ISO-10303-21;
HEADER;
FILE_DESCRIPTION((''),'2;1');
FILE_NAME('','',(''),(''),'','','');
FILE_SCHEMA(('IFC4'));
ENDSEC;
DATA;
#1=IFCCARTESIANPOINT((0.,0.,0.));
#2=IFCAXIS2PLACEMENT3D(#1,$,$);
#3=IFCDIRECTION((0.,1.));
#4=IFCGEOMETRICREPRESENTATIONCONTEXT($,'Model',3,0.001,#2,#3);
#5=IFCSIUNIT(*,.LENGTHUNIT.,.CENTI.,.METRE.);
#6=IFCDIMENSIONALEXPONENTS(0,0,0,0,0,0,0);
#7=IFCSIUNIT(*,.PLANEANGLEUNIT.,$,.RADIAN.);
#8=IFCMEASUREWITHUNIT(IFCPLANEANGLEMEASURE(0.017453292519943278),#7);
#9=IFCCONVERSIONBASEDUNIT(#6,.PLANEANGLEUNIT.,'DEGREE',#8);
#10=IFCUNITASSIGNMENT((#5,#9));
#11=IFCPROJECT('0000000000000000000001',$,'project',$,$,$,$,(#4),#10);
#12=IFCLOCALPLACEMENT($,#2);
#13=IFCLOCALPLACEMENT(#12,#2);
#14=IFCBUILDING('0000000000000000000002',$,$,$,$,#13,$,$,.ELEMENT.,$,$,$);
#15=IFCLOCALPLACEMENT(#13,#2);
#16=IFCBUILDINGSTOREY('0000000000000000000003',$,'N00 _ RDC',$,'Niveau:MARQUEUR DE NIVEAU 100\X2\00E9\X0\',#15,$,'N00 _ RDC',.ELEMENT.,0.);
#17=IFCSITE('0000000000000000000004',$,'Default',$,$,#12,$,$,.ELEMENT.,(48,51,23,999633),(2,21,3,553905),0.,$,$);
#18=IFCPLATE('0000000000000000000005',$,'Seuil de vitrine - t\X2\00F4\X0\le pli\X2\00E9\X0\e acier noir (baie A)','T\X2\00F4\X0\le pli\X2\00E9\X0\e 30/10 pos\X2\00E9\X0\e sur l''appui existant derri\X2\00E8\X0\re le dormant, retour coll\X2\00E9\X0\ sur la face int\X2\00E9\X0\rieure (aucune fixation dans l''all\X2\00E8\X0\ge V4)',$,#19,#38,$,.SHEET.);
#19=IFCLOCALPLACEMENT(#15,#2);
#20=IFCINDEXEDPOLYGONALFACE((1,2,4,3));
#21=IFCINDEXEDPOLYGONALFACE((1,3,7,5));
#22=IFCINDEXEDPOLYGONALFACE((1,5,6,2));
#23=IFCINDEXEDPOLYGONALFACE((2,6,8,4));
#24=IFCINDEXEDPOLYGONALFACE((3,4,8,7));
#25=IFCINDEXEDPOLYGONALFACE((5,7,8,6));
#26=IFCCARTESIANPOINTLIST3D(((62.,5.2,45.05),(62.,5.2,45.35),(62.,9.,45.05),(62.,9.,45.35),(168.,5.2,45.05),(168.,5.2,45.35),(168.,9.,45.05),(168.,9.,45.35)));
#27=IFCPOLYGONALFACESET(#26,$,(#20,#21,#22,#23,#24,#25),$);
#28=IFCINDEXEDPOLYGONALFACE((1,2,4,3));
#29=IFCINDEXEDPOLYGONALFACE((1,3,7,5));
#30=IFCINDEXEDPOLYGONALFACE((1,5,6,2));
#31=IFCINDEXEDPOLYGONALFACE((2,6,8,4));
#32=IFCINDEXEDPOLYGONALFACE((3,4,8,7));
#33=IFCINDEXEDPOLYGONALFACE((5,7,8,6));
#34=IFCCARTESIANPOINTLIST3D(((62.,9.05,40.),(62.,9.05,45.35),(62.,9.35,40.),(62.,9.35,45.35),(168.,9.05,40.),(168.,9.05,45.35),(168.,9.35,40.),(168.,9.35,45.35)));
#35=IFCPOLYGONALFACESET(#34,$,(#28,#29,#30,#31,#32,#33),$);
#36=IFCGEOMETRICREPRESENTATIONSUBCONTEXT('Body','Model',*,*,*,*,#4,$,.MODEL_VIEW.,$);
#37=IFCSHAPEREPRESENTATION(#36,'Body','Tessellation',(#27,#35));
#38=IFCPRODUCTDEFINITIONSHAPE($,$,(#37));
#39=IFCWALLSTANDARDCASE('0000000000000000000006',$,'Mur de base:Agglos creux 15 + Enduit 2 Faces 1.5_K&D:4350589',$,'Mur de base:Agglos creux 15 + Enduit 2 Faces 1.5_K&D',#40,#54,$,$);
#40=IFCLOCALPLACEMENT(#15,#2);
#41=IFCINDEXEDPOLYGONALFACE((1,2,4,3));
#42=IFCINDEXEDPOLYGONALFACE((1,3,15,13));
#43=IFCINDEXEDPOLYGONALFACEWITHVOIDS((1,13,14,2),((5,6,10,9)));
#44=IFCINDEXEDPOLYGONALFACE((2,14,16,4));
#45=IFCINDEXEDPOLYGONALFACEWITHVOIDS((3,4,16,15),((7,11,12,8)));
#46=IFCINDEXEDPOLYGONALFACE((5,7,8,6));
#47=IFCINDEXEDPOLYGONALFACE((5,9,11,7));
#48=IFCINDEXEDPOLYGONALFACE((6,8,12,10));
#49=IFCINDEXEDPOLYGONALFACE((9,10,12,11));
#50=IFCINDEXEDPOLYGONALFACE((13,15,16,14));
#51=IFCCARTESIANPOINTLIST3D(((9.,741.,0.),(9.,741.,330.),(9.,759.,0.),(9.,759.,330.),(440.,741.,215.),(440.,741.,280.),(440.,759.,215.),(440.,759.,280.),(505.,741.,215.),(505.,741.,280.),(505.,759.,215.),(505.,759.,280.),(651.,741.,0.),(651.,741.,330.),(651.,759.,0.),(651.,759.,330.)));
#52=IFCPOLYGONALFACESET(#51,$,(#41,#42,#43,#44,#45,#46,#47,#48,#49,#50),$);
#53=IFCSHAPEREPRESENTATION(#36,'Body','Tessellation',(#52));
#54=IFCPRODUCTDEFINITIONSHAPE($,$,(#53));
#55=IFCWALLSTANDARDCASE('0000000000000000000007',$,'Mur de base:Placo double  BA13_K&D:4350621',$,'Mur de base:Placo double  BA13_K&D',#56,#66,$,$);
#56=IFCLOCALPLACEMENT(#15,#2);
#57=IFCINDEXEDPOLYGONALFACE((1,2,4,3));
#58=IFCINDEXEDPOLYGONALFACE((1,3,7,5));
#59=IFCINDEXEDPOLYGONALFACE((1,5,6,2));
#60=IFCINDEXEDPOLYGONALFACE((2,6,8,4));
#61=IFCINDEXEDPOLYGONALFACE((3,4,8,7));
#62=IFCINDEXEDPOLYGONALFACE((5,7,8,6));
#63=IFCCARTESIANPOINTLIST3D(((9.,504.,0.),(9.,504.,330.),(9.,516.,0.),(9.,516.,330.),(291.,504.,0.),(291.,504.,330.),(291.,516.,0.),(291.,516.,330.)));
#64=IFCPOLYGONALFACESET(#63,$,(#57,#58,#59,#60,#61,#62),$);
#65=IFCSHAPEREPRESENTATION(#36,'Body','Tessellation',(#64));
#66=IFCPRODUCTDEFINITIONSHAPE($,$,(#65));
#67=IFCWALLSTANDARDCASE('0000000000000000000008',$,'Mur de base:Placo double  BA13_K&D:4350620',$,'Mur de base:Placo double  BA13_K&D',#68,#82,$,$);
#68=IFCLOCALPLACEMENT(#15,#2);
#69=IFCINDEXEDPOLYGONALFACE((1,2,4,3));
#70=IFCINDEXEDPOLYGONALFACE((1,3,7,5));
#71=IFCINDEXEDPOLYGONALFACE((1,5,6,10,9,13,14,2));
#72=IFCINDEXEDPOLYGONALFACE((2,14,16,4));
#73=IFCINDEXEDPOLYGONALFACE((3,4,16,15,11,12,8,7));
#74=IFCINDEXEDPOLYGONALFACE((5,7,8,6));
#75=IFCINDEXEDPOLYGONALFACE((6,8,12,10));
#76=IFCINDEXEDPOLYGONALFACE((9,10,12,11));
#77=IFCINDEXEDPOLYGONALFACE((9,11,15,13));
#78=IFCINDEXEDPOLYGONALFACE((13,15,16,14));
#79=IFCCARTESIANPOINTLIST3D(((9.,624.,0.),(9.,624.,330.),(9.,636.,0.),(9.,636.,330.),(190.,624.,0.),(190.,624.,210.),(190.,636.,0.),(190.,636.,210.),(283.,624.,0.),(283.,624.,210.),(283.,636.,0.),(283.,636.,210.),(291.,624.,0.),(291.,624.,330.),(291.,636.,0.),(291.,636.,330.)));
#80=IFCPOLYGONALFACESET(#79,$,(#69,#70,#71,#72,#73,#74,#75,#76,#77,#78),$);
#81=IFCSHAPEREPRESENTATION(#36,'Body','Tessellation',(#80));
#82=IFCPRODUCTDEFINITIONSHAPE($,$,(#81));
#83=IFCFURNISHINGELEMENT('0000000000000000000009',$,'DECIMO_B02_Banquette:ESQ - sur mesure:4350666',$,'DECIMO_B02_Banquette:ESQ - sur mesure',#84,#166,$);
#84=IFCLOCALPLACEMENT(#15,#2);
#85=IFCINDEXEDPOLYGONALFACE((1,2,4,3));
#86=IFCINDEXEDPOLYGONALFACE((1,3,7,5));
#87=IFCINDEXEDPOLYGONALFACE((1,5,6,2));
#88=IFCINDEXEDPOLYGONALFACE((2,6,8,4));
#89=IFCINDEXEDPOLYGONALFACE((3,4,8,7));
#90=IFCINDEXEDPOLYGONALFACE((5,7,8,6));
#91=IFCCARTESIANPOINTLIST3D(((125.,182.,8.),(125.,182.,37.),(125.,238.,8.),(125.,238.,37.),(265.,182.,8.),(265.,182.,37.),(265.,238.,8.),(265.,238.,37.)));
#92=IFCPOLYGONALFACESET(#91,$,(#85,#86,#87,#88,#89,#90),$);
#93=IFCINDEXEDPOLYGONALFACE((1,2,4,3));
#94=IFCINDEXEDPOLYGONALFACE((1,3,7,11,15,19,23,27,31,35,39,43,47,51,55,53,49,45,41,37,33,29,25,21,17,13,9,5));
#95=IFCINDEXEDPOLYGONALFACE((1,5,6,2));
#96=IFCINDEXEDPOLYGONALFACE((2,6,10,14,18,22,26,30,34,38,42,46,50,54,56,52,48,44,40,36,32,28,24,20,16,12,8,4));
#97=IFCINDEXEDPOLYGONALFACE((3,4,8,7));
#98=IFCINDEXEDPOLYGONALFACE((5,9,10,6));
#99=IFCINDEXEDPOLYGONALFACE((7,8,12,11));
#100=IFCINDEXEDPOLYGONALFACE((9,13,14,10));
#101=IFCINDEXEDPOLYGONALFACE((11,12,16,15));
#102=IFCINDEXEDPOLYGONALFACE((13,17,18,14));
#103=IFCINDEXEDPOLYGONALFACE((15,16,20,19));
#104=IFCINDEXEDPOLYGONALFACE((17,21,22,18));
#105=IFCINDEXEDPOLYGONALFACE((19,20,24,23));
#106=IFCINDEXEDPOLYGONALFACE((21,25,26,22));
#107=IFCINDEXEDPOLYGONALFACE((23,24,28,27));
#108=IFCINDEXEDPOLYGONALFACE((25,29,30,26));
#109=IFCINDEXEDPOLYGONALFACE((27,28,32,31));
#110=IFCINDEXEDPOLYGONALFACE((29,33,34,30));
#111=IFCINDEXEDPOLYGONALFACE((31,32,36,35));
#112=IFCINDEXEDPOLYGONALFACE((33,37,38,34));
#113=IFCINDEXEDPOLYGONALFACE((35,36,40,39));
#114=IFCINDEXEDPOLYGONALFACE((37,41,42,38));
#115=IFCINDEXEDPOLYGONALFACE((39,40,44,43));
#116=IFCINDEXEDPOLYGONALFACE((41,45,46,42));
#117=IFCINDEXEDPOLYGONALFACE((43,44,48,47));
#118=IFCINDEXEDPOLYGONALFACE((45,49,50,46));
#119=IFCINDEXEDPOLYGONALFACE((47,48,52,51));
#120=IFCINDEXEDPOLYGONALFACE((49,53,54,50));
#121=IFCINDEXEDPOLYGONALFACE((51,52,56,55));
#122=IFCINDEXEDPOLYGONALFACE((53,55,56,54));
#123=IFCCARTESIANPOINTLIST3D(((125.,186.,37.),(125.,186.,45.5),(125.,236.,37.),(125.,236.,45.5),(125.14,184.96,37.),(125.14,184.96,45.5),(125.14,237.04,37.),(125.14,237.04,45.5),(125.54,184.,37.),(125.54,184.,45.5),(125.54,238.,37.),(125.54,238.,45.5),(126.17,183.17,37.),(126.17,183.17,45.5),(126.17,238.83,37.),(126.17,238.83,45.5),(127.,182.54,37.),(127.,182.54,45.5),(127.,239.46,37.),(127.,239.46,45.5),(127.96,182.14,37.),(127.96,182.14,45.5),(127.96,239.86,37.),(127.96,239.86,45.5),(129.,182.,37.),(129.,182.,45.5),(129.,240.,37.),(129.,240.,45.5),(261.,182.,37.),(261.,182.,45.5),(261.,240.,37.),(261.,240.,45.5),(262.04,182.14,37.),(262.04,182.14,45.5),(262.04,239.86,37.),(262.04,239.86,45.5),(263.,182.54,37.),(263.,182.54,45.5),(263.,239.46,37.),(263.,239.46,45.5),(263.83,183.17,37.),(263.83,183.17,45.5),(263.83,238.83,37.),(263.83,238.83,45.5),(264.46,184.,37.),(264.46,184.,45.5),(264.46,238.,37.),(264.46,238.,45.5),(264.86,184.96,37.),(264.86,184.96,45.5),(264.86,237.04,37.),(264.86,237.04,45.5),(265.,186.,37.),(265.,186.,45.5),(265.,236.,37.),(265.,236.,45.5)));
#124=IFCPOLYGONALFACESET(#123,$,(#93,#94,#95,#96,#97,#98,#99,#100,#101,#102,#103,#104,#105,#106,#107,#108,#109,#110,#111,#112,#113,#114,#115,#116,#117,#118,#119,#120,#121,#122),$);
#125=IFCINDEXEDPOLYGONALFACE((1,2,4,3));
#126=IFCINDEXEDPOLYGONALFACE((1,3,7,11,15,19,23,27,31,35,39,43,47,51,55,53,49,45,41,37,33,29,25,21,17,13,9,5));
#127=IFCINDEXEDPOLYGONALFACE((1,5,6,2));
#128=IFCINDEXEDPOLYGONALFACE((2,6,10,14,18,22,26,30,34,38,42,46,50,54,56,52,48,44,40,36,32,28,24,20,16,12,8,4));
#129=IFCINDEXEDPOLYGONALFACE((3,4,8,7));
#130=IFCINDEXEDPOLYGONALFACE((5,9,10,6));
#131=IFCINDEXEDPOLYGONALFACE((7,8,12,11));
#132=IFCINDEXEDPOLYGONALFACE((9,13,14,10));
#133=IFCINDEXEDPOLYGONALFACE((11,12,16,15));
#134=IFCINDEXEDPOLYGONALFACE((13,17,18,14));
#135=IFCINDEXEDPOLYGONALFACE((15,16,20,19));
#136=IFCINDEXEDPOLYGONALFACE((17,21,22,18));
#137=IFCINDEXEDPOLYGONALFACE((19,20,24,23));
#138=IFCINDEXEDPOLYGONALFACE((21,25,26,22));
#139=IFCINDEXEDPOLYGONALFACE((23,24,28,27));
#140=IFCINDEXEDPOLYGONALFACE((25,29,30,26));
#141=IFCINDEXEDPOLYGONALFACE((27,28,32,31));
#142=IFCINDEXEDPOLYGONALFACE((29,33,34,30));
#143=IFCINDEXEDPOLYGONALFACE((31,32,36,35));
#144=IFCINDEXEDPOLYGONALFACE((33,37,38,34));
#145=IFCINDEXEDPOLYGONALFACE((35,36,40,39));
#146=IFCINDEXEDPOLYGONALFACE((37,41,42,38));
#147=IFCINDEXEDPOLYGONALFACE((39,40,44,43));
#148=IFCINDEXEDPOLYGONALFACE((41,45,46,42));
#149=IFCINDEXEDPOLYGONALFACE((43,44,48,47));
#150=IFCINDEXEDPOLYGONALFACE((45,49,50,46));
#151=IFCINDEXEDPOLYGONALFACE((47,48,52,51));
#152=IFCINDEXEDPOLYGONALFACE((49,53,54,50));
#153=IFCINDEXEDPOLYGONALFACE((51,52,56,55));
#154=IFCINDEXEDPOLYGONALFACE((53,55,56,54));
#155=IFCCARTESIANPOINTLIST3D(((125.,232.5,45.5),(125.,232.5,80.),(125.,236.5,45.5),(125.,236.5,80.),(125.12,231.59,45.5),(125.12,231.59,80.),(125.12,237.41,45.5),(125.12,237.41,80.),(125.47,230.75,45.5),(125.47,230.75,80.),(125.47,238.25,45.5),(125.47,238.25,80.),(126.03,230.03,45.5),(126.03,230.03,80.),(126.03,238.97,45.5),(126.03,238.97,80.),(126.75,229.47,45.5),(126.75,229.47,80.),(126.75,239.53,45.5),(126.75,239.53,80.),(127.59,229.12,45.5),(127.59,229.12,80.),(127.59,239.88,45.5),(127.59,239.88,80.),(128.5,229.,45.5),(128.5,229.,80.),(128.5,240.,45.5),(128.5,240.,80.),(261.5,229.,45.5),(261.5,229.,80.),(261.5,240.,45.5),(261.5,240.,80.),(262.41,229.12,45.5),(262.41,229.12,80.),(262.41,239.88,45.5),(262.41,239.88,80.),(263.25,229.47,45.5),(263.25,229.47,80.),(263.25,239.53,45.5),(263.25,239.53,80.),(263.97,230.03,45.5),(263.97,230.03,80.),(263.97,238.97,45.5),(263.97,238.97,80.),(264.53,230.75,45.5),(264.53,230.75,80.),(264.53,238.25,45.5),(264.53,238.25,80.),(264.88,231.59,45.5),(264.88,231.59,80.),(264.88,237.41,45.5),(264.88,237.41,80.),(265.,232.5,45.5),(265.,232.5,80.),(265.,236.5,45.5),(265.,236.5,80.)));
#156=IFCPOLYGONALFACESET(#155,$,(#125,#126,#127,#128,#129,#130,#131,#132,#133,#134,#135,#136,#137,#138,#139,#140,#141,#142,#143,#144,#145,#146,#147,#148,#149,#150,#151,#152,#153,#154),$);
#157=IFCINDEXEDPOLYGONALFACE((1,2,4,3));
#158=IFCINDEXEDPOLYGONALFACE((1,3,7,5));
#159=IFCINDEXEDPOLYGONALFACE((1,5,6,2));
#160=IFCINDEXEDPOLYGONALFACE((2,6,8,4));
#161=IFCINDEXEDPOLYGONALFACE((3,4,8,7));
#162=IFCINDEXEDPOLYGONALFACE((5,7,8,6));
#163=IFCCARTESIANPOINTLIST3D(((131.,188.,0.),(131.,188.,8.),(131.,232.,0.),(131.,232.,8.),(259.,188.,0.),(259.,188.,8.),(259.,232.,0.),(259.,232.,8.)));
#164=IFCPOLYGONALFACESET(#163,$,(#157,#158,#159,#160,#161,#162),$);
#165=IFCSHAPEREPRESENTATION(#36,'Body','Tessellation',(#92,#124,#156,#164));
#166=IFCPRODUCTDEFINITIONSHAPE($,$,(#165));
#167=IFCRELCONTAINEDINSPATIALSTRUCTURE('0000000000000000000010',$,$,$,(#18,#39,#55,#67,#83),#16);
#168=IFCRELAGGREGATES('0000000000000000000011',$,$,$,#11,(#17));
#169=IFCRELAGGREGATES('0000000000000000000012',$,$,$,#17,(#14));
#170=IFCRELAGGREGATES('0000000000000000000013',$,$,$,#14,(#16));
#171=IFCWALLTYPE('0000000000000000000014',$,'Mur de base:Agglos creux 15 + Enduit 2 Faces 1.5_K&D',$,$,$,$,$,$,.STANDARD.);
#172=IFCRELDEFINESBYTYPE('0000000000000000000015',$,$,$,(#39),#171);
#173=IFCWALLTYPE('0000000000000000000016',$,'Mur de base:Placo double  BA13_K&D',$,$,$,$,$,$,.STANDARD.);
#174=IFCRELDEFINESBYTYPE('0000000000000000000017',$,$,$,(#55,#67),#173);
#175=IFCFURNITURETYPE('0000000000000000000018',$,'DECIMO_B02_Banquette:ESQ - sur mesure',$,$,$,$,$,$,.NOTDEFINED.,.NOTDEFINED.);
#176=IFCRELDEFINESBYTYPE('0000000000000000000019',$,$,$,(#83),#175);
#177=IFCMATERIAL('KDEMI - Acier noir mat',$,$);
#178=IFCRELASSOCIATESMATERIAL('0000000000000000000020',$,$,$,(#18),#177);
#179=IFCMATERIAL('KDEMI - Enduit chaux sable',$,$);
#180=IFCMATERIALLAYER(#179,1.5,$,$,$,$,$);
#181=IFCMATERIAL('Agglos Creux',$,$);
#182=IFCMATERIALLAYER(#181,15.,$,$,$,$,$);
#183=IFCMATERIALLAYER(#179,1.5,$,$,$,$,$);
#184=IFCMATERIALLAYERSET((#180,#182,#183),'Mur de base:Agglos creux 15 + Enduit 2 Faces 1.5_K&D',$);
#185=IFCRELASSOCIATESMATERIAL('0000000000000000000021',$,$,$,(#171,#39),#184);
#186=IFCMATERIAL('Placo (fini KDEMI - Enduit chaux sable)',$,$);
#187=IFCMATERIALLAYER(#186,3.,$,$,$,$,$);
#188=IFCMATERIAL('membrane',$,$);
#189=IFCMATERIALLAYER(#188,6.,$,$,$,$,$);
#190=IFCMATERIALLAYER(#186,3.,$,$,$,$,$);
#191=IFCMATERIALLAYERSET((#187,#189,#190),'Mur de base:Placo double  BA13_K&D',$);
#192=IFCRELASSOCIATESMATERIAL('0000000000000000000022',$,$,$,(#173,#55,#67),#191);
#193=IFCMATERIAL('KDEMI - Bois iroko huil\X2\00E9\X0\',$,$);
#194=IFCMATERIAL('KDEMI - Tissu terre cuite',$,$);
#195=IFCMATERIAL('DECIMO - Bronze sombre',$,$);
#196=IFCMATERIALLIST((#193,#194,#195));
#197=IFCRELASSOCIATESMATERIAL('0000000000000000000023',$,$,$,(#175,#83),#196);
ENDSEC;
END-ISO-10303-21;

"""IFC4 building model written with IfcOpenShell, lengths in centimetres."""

from ifc_helpers import new_model, entity, si_unit, converted_unit, direction, frame, frame_2d, origin, origin_with_axes, origin_2d_with_axis, place, context, subcontext, project, spatial, polyline, circle_curve, parameter, trimmed, segment, composite_curve, rectangle, outline, extrude, source, transform, mapped, material, material_list, layer, layer_set, layer_usage, type_object, type_shapes, element, save


model = new_model("IFC4")

# Units and contexts
model_context = context("Model", 3, precision=0.001, world=origin(), true_north=direction((0.0, 1.0)))
body_context = subcontext(model_context, "Body", "Model", "MODEL_VIEW")
ifc_project = project(units=[si_unit("LENGTHUNIT", "METRE", prefix="CENTI"), converted_unit("PLANEANGLEUNIT", "DEGREE", entity("IfcPlaneAngleMeasure", 0.017453292519943278), si_unit("PLANEANGLEUNIT", "RADIAN"), dimensions=[0, 0, 0, 0, 0, 0, 0])], contexts=[model_context])

# Site, building, storey
site_placement = place(None, origin())
site = spatial("IfcSite", under=ifc_project, at=site_placement, Name="Default", CompositionType="ELEMENT", RefLatitude=(48, 51, 23, 999633), RefLongitude=(2, 21, 3, 553905), RefElevation=0.0)
building_placement = place(site_placement, origin())
building = spatial("IfcBuilding", under=site, at=building_placement, CompositionType="ELEMENT")
storey_placement = place(building_placement, origin())
storey = spatial("IfcBuildingStorey", under=building, at=storey_placement, Name="N00 _ RDC", ObjectType="Niveau:MARQUEUR DE NIVEAU 100é", LongName="N00 _ RDC", CompositionType="ELEMENT", Elevation=0.0)

# Plate
ifc_material_1 = material(Name="KDEMI - Acier noir mat")
plate_placement = place(storey_placement, origin_with_axes())
element("IfcPlate", 1, at=plate_placement, inside=storey, material=ifc_material_1, Name="Seuil de vitrine - tôle pliée acier noir (baie A)", Description="Tôle pliée 30/10 posée sur l'appui existant derrière le dormant, retour collé sur la face intérieure (aucune fixation dans l'allège V4)", PredefinedType="SHEET", context=body_context, shape_type="SweptSolid", body=[
    extrude(rectangle(XDim=106.0, YDim=3.8, at=frame_2d((115.0, 7.1))), frame((0.0, 0.0, 45.05)), (0.0, 0.0, 1.0), 0.3),
    extrude(rectangle(XDim=106.0, YDim=0.3, at=frame_2d((115.0, 9.2))), frame((0.0, 0.0, 40.0)), (0.0, 0.0, 1.0), 5.35),
])

# Wall, opening
ifc_material_2 = material(Name="KDEMI - Enduit chaux sable")
ifc_layer_1 = layer(ifc_material_2, 1.5)
ifc_material_3 = material(Name="Agglos Creux")
ifc_layer_2 = layer(ifc_material_3, 15.0)
ifc_layer_3 = layer(ifc_material_2, 1.5)
ifc_layer_set_1 = layer_set([ifc_layer_1, ifc_layer_2, ifc_layer_3], Name="Mur de base:Agglos creux 15 + Enduit 2 Faces 1.5_K&D")
ifc_layer_usage_1 = layer_usage(ifc_layer_set_1, "AXIS2", "NEGATIVE", 9.0)
wall_type_1 = type_object("IfcWallType", Name="Mur de base:Agglos creux 15 + Enduit 2 Faces 1.5_K&D", PredefinedType="STANDARD", material=ifc_layer_set_1)
wall_1_placement = place(storey_placement, frame((9.0, 750.0, 0.0)))
wall_1 = element("IfcWallStandardCase", 2, at=wall_1_placement, inside=storey, type_object=wall_type_1, material=ifc_layer_usage_1, Name="Mur de base:Agglos creux 15 + Enduit 2 Faces 1.5_K&D:4350589", ObjectType="Mur de base:Agglos creux 15 + Enduit 2 Faces 1.5_K&D", context=body_context, shape_type="SweptSolid", body=[
    extrude(rectangle(XDim=642.0, YDim=18.0, at=frame_2d((321.0, 0.0), x_axis=(-1.0, 0.0))), origin(), (0.0, 0.0, 1.0), 330.0),
])
opening_1_placement = place(wall_1_placement, origin())
element("IfcOpeningElement", 3, at=opening_1_placement, cuts=wall_1, ObjectType="Opening", context=body_context, shape_type="SweptSolid", body=[
    extrude(rectangle(XDim=65.0, YDim=65.0, at=frame_2d((0.0, 0.0), x_axis=(1.0, 0.0))), frame((463.5, -9.0, 247.5), z_axis=(0.0, 1.0, 0.0), x_axis=(0.0, 0.0, -1.0)), (0.0, 0.0, 1.0), 18.0),
])

# Wall
ifc_material_4 = material(Name="Placo (fini KDEMI - Enduit chaux sable)")
ifc_layer_4 = layer(ifc_material_4, 3.0)
ifc_material_5 = material(Name="membrane")
ifc_layer_5 = layer(ifc_material_5, 6.0)
ifc_layer_6 = layer(ifc_material_4, 3.0)
ifc_layer_set_2 = layer_set([ifc_layer_4, ifc_layer_5, ifc_layer_6], Name="Mur de base:Placo double  BA13_K&D")
ifc_layer_usage_2 = layer_usage(ifc_layer_set_2, "AXIS2", "POSITIVE", -6.0)
wall_type_2 = type_object("IfcWallType", Name="Mur de base:Placo double  BA13_K&D", PredefinedType="STANDARD", material=ifc_layer_set_2)
wall_2_placement = place(storey_placement, frame((9.0, 510.0, 0.0)))
element("IfcWallStandardCase", 4, at=wall_2_placement, inside=storey, type_object=wall_type_2, material=ifc_layer_usage_2, Name="Mur de base:Placo double  BA13_K&D:4350621", ObjectType="Mur de base:Placo double  BA13_K&D", context=body_context, shape_type="SweptSolid", body=[
    extrude(rectangle(XDim=282.0, YDim=12.0, at=frame_2d((141.0, 0.0), x_axis=(-1.0, 0.0))), origin(), (0.0, 0.0, 1.0), 330.0),
])

# Wall, opening
ifc_layer_usage_3 = layer_usage(ifc_layer_set_2, "AXIS2", "NEGATIVE", 6.0)
wall_3_placement = place(storey_placement, frame((9.0, 630.0, 0.0)))
wall_3 = element("IfcWallStandardCase", 5, at=wall_3_placement, inside=storey, type_object=wall_type_2, material=ifc_layer_usage_3, Name="Mur de base:Placo double  BA13_K&D:4350620", ObjectType="Mur de base:Placo double  BA13_K&D", context=body_context, shape_type="SweptSolid", body=[
    extrude(rectangle(XDim=282.0, YDim=12.0, at=frame_2d((141.0, 0.0), x_axis=(-1.0, 0.0))), origin(), (0.0, 0.0, 1.0), 330.0),
])
opening_2_placement = place(wall_3_placement, frame((-9.0, -630.0, 0.0), z_axis=(0.0, 0.0, 1.0), x_axis=(1.0, 0.0, 0.0)))
element("IfcOpeningElement", 6, at=opening_2_placement, inside=storey, cuts=wall_3, context=body_context, shape_type="SweptSolid", body=[
    extrude(rectangle(XDim=93.0, YDim=16.0, at=frame_2d((236.5, 630.0))), origin(), (0.0, 0.0, 1.0), 210.0),
])

# Furnishing element
ifc_material_6 = material(Name="KDEMI - Tissu terre cuite")
ifc_material_7 = material(Name="KDEMI - Bois iroko huilé")
ifc_material_8 = material(Name="DECIMO - Bronze sombre")
ifc_material_list_1 = material_list([ifc_material_7, ifc_material_6, ifc_material_8])
furniture_type_1 = type_object("IfcFurnitureType", Name="DECIMO_B02_Banquette:ESQ - sur mesure", AssemblyPlace="NOTDEFINED", material=ifc_material_list_1)
shared_shape_1 = source(origin(), body_context, "Body", "SweptSolid", [
    extrude(rectangle(XDim=140.0, YDim=56.0, at=origin_2d_with_axis()), frame((70.0, 28.0, 8.0)), (0.0, 0.0, 1.0), 29.0),
    extrude(outline(composite_curve([segment(polyline([(-66.0, -29.0), (66.0, -29.0)]), True, "CONTINUOUS"), segment(trimmed(circle_curve(frame_2d((66.0, -25.0), x_axis=(1.0, 0.0)), 4.0), [parameter(270.0)], [parameter(0.0)], True, "PARAMETER"), True, "CONTINUOUS"), segment(polyline([(70.0, -25.0), (70.0, 25.0)]), True, "CONTINUOUS"), segment(trimmed(circle_curve(frame_2d((66.0, 25.0), x_axis=(1.0, 0.0)), 4.0), [parameter(0.0)], [parameter(90.0)], True, "PARAMETER"), True, "CONTINUOUS"), segment(polyline([(66.0, 29.0), (-66.0, 29.0)]), True, "CONTINUOUS"), segment(trimmed(circle_curve(frame_2d((-66.0, 25.0), x_axis=(1.0, 0.0)), 4.0), [parameter(90.0)], [parameter(180.0)], True, "PARAMETER"), True, "CONTINUOUS"), segment(polyline([(-70.0, 25.0), (-70.0, -25.0)]), True, "CONTINUOUS"), segment(trimmed(circle_curve(frame_2d((-66.0, -25.0), x_axis=(1.0, 0.0)), 4.0), [parameter(180.0)], [parameter(270.0)], True, "PARAMETER"), True, "CONTINUOUS")], self_intersect=False)), frame((70.0, 29.0, 37.0)), (0.0, 0.0, 1.0), 8.5),
    extrude(outline(composite_curve([segment(polyline([(-66.5, -5.5), (66.5, -5.5)]), True, "CONTINUOUS"), segment(trimmed(circle_curve(frame_2d((66.5, -2.0), x_axis=(1.0, 0.0)), 3.5), [parameter(270.0)], [parameter(0.0)], True, "PARAMETER"), True, "CONTINUOUS"), segment(polyline([(70.0, -2.0), (70.0, 2.0)]), True, "CONTINUOUS"), segment(trimmed(circle_curve(frame_2d((66.5, 2.0), x_axis=(1.0, 0.0)), 3.5), [parameter(0.0)], [parameter(90.0)], True, "PARAMETER"), True, "CONTINUOUS"), segment(polyline([(66.5, 5.5), (-66.5, 5.5)]), True, "CONTINUOUS"), segment(trimmed(circle_curve(frame_2d((-66.5, 2.0), x_axis=(1.0, 0.0)), 3.5), [parameter(90.0)], [parameter(180.0)], True, "PARAMETER"), True, "CONTINUOUS"), segment(polyline([(-70.0, 2.0), (-70.0, -2.0)]), True, "CONTINUOUS"), segment(trimmed(circle_curve(frame_2d((-66.5, -2.0), x_axis=(1.0, 0.0)), 3.5), [parameter(180.0)], [parameter(270.0)], True, "PARAMETER"), True, "CONTINUOUS")], self_intersect=False)), frame((70.0, 52.5, 45.5)), (0.0, 0.0, 1.0), 34.5),
    extrude(rectangle(XDim=128.0, YDim=44.0, at=frame_2d((0.0, 0.0), x_axis=(1.0, 0.0))), frame((70.0, 28.0, 0.0)), (0.0, 0.0, 1.0), 8.0),
])
type_shapes(furniture_type_1, [shared_shape_1])
furnishing_1_placement = place(storey_placement, frame((125.0, 182.0, 0.0)))
element("IfcFurnishingElement", 7, at=furnishing_1_placement, inside=storey, type_object=furniture_type_1, material=ifc_material_list_1, Name="DECIMO_B02_Banquette:ESQ - sur mesure:4350666", ObjectType="DECIMO_B02_Banquette:ESQ - sur mesure", context=body_context, shape_type="MappedRepresentation", body=[
    mapped(shared_shape_1, transform((0.0, 0.0, 0.0), scale=1.0)),
])

save(model, "model.ifc")
